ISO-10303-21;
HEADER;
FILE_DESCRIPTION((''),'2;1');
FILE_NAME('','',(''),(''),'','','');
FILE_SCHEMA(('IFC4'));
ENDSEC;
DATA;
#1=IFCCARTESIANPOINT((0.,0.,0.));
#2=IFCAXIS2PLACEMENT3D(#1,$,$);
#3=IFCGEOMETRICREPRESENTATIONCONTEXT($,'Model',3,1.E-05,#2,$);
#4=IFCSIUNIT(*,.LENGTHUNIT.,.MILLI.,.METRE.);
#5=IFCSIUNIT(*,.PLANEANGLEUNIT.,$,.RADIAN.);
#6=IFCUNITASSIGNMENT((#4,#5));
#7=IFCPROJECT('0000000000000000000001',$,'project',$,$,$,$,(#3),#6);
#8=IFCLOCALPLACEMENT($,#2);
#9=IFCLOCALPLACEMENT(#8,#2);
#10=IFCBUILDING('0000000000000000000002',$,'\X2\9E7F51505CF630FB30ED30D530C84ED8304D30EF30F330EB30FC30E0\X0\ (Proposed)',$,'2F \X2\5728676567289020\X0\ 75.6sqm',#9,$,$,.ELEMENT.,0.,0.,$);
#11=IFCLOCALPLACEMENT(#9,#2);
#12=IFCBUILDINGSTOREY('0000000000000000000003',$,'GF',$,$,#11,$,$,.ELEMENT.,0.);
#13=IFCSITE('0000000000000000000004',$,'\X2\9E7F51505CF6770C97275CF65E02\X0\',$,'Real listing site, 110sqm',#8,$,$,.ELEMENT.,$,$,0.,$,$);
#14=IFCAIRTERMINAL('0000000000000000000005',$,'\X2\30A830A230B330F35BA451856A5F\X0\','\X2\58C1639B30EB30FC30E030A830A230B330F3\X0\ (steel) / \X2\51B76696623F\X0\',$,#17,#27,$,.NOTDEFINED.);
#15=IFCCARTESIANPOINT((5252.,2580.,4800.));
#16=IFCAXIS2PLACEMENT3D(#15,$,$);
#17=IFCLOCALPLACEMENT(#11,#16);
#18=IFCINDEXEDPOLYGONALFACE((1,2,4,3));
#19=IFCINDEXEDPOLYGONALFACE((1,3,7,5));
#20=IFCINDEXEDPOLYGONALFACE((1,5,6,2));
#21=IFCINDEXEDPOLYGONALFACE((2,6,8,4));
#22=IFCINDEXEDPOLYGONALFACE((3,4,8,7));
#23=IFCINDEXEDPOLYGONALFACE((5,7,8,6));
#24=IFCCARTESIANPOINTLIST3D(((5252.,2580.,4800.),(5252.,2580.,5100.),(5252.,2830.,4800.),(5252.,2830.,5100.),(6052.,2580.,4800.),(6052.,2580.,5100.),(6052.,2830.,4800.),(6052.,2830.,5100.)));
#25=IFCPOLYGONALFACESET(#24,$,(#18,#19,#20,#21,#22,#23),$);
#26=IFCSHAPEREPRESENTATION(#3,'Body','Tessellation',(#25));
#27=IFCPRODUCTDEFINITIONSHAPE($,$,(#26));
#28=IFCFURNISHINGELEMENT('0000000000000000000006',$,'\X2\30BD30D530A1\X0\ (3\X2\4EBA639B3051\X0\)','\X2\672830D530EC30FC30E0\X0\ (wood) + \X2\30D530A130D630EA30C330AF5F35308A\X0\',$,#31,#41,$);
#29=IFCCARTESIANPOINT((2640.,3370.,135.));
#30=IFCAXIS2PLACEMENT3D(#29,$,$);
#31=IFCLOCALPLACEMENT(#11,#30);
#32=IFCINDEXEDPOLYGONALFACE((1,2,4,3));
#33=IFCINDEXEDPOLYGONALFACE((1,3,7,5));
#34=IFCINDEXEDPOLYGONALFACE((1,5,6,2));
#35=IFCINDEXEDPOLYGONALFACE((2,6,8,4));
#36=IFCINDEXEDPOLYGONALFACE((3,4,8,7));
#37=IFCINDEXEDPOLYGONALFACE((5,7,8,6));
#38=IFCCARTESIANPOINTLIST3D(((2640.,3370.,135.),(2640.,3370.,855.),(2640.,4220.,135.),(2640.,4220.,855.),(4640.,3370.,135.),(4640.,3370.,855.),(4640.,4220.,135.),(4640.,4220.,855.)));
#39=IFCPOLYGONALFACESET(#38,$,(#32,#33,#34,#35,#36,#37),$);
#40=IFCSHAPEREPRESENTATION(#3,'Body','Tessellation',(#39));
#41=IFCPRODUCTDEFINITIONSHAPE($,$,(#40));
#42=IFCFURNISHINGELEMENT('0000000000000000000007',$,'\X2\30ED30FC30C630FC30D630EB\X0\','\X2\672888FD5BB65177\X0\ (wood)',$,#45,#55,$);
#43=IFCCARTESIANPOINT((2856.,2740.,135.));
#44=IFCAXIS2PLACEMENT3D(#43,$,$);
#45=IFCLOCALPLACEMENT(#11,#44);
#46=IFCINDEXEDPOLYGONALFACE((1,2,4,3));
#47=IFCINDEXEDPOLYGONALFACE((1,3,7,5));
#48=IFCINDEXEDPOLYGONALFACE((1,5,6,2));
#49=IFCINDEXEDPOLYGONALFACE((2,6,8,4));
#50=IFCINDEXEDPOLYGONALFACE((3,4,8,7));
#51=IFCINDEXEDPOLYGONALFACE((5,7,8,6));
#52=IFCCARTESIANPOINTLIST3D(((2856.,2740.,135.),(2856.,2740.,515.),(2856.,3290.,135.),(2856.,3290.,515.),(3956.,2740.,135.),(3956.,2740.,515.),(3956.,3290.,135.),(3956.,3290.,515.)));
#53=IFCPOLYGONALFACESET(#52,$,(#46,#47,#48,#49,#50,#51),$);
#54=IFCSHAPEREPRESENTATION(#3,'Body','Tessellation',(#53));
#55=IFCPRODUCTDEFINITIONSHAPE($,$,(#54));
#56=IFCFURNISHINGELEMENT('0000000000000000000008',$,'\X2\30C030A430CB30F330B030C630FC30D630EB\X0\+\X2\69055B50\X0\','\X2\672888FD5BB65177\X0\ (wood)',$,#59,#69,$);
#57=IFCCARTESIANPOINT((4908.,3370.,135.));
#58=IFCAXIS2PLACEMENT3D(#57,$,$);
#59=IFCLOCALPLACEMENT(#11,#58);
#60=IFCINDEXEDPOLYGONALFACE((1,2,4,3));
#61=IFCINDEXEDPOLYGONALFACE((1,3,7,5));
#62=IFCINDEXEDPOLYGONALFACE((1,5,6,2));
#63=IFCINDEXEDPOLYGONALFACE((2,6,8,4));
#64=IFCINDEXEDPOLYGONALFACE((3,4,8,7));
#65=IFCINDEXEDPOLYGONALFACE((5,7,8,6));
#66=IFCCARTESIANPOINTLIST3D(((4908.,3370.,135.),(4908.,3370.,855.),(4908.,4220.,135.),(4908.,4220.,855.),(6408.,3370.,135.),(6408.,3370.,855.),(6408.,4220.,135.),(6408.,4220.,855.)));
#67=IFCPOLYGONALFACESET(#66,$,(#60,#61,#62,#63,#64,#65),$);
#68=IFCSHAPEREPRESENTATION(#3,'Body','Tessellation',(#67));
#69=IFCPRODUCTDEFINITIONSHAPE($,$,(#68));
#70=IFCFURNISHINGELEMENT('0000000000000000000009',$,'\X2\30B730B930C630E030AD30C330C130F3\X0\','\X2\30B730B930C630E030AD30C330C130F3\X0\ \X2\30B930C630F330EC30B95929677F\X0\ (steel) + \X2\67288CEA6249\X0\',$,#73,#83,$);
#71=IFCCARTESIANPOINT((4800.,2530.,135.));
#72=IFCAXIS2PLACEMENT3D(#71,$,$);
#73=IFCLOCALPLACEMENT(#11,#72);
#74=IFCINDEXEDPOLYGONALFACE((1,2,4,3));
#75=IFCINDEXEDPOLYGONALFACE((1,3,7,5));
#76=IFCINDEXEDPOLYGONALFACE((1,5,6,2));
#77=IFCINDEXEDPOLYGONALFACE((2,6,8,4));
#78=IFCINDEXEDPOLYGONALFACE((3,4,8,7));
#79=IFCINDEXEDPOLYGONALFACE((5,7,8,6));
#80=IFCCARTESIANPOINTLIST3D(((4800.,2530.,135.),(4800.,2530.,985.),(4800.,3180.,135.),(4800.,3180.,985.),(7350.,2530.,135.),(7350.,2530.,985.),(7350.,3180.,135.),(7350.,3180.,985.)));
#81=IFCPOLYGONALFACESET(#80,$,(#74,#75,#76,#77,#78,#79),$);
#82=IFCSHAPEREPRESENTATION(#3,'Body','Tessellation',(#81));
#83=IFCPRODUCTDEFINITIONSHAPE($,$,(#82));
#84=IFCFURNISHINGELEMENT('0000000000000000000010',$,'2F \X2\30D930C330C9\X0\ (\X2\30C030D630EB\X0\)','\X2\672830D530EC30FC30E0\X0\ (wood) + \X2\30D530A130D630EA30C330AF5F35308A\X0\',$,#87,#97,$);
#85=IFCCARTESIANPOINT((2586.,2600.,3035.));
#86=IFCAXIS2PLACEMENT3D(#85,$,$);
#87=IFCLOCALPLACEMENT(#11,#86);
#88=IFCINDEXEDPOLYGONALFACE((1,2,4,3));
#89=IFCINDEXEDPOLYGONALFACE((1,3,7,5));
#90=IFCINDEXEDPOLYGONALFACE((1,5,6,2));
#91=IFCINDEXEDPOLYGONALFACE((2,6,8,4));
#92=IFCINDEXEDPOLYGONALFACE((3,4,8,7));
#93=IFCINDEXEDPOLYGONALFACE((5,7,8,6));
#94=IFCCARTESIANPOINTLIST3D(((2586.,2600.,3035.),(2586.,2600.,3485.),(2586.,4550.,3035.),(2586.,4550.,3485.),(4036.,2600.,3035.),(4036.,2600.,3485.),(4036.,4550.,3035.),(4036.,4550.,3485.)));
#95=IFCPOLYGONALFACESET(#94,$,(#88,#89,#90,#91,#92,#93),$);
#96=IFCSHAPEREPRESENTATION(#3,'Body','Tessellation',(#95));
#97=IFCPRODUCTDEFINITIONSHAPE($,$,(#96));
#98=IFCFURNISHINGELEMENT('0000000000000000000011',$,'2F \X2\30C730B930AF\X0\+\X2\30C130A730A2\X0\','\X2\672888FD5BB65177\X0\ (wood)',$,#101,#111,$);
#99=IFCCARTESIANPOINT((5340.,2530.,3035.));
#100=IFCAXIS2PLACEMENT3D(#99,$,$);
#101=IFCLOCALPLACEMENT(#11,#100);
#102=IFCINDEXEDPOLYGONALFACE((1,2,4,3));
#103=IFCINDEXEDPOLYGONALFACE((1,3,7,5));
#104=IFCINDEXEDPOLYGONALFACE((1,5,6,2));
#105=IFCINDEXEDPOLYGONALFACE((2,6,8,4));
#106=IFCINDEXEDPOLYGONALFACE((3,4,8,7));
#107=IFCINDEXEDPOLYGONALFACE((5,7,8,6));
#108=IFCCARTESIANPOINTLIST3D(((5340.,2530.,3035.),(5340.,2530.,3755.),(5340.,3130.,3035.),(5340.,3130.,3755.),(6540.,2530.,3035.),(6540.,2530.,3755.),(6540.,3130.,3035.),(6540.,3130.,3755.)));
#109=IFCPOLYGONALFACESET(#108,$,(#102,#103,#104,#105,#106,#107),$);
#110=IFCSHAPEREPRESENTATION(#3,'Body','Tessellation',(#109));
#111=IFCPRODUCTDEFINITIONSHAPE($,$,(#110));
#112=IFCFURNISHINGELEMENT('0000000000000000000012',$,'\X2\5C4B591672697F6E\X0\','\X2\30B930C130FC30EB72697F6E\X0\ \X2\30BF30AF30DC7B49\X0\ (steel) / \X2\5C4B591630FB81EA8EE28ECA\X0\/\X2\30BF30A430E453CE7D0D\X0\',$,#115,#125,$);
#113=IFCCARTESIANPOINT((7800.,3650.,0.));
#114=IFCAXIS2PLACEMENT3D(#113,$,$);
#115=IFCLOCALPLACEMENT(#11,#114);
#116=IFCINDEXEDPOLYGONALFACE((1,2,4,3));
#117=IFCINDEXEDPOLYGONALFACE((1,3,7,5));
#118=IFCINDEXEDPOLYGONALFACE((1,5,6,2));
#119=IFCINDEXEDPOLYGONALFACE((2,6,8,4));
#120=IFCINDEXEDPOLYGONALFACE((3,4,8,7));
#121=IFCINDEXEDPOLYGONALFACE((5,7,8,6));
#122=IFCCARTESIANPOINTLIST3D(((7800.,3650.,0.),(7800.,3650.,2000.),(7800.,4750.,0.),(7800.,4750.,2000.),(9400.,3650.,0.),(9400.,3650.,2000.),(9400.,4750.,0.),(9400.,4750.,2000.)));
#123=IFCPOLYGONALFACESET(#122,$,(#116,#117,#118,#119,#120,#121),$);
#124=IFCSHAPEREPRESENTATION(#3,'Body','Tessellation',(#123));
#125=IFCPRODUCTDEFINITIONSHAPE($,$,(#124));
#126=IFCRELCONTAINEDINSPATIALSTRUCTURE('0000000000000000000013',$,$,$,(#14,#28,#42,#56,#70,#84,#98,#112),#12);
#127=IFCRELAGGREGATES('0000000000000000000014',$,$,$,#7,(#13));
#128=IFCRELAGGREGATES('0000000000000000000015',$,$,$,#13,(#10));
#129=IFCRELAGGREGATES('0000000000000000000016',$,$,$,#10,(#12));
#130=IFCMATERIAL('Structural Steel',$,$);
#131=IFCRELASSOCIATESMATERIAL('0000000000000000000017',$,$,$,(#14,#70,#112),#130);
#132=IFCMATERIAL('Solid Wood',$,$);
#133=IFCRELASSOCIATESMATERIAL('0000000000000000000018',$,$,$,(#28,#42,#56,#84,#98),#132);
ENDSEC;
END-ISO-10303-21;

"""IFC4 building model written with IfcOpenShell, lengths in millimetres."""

from ifc_helpers import new_model, si_unit, frame, frame_2d, origin, place, context, project, spatial, rectangle, extrude, material, element, save


model = new_model("IFC4")

# Units and contexts
model_context = context("Model", 3, precision=1e-05, world=origin())
ifc_project = project(units=[si_unit("LENGTHUNIT", "METRE", prefix="MILLI"), si_unit("PLANEANGLEUNIT", "RADIAN")], contexts=[model_context])

# Site, building, storey
site_placement = place(None, origin())
site = spatial("IfcSite", under=ifc_project, at=site_placement, Name="鹿児島県霧島市", ObjectType="Real listing site, 110sqm", CompositionType="ELEMENT", RefElevation=0.0)
building_placement = place(site_placement, origin())
building = spatial("IfcBuilding", under=site, at=building_placement, Name="鹿児島・ロフト付きワンルーム (Proposed)", ObjectType="2F 在来木造 75.6sqm", CompositionType="ELEMENT", ElevationOfRefHeight=0.0, ElevationOfTerrain=0.0)
storey_placement = place(building_placement, origin())
storey = spatial("IfcBuildingStorey", under=building, at=storey_placement, Name="GF", CompositionType="ELEMENT", Elevation=0.0)

# Shared definitions
ifc_material_1 = material(Name="Solid Wood")

# Shared definitions
ifc_material_2 = material(Name="Structural Steel")

# Air terminal
air_terminal_1_placement = place(storey_placement, frame((5252.0, 2580.0, 4800.0)))
element("IfcAirTerminal", 1, at=air_terminal_1_placement, inside=storey, material=ifc_material_2, Name="エアコン室内機", Description="壁掛ルームエアコン (steel) / 冷暖房", PredefinedType="NOTDEFINED", context=model_context, shape_type="SweptSolid", body=[
    extrude(rectangle(XDim=800.0, YDim=250.0, at=frame_2d((400.0, 125.0))), frame((5252.0, 2580.0, 4800.0)), (0.0, 0.0, 1.0), 300.0),
])

# Furnishing elements
furnishing_1_placement = place(storey_placement, frame((2640.0, 3370.0, 135.0)))
element("IfcFurnishingElement", 2, at=furnishing_1_placement, inside=storey, material=ifc_material_1, Name="ソファ (3人掛け)", Description="木フレーム (wood) + ファブリック張り", context=model_context, shape_type="SweptSolid", body=[
    extrude(rectangle(XDim=2000.0, YDim=850.0, at=frame_2d((1000.0, 425.0))), frame((2640.0, 3370.0, 135.0)), (0.0, 0.0, 1.0), 720.0),
])
furnishing_2_placement = place(storey_placement, frame((2856.0, 2740.0, 135.0)))
element("IfcFurnishingElement", 3, at=furnishing_2_placement, inside=storey, material=ifc_material_1, Name="ローテーブル", Description="木製家具 (wood)", context=model_context, shape_type="SweptSolid", body=[
    extrude(rectangle(XDim=1100.0, YDim=550.0, at=frame_2d((550.0, 275.0))), frame((2856.0, 2740.0, 135.0)), (0.0, 0.0, 1.0), 380.0),
])
furnishing_3_placement = place(storey_placement, frame((4908.0, 3370.0, 135.0)))
element("IfcFurnishingElement", 4, at=furnishing_3_placement, inside=storey, material=ifc_material_1, Name="ダイニングテーブル+椅子", Description="木製家具 (wood)", context=model_context, shape_type="SweptSolid", body=[
    extrude(rectangle(XDim=1500.0, YDim=850.0, at=frame_2d((750.0, 425.0))), frame((4908.0, 3370.0, 135.0)), (0.0, 0.0, 1.0), 720.0),
])
furnishing_4_placement = place(storey_placement, frame((4800.0, 2530.0, 135.0)))
element("IfcFurnishingElement", 5, at=furnishing_4_placement, inside=storey, material=ifc_material_2, Name="システムキッチン", Description="システムキッチン ステンレス天板 (steel) + 木質扉", context=model_context, shape_type="SweptSolid", body=[
    extrude(rectangle(XDim=2550.0, YDim=650.0, at=frame_2d((1275.0, 325.0))), frame((4800.0, 2530.0, 135.0)), (0.0, 0.0, 1.0), 850.0),
])
furnishing_5_placement = place(storey_placement, frame((2586.0, 2600.0, 3035.0)))
element("IfcFurnishingElement", 6, at=furnishing_5_placement, inside=storey, material=ifc_material_1, Name="2F ベッド (ダブル)", Description="木フレーム (wood) + ファブリック張り", context=model_context, shape_type="SweptSolid", body=[
    extrude(rectangle(XDim=1450.0, YDim=1950.0, at=frame_2d((725.0, 975.0))), frame((2586.0, 2600.0, 3035.0)), (0.0, 0.0, 1.0), 450.0),
])
furnishing_6_placement = place(storey_placement, frame((5340.0, 2530.0, 3035.0)))
element("IfcFurnishingElement", 7, at=furnishing_6_placement, inside=storey, material=ifc_material_1, Name="2F デスク+チェア", Description="木製家具 (wood)", context=model_context, shape_type="SweptSolid", body=[
    extrude(rectangle(XDim=1200.0, YDim=600.0, at=frame_2d((600.0, 300.0))), frame((5340.0, 2530.0, 3035.0)), (0.0, 0.0, 1.0), 720.0),
])
furnishing_7_placement = place(storey_placement, frame((7800.0, 3650.0, 0.0)))
element("IfcFurnishingElement", 8, at=furnishing_7_placement, inside=storey, material=ifc_material_2, Name="屋外物置", Description="スチール物置 タクボ等 (steel) / 屋外・自転車/タイヤ収納", context=model_context, shape_type="SweptSolid", body=[
    extrude(rectangle(XDim=1600.0, YDim=1100.0, at=frame_2d((800.0, 550.0))), frame((7800.0, 3650.0, 0.0)), (0.0, 0.0, 1.0), 2000.0),
])

save(model, "model.ifc")
